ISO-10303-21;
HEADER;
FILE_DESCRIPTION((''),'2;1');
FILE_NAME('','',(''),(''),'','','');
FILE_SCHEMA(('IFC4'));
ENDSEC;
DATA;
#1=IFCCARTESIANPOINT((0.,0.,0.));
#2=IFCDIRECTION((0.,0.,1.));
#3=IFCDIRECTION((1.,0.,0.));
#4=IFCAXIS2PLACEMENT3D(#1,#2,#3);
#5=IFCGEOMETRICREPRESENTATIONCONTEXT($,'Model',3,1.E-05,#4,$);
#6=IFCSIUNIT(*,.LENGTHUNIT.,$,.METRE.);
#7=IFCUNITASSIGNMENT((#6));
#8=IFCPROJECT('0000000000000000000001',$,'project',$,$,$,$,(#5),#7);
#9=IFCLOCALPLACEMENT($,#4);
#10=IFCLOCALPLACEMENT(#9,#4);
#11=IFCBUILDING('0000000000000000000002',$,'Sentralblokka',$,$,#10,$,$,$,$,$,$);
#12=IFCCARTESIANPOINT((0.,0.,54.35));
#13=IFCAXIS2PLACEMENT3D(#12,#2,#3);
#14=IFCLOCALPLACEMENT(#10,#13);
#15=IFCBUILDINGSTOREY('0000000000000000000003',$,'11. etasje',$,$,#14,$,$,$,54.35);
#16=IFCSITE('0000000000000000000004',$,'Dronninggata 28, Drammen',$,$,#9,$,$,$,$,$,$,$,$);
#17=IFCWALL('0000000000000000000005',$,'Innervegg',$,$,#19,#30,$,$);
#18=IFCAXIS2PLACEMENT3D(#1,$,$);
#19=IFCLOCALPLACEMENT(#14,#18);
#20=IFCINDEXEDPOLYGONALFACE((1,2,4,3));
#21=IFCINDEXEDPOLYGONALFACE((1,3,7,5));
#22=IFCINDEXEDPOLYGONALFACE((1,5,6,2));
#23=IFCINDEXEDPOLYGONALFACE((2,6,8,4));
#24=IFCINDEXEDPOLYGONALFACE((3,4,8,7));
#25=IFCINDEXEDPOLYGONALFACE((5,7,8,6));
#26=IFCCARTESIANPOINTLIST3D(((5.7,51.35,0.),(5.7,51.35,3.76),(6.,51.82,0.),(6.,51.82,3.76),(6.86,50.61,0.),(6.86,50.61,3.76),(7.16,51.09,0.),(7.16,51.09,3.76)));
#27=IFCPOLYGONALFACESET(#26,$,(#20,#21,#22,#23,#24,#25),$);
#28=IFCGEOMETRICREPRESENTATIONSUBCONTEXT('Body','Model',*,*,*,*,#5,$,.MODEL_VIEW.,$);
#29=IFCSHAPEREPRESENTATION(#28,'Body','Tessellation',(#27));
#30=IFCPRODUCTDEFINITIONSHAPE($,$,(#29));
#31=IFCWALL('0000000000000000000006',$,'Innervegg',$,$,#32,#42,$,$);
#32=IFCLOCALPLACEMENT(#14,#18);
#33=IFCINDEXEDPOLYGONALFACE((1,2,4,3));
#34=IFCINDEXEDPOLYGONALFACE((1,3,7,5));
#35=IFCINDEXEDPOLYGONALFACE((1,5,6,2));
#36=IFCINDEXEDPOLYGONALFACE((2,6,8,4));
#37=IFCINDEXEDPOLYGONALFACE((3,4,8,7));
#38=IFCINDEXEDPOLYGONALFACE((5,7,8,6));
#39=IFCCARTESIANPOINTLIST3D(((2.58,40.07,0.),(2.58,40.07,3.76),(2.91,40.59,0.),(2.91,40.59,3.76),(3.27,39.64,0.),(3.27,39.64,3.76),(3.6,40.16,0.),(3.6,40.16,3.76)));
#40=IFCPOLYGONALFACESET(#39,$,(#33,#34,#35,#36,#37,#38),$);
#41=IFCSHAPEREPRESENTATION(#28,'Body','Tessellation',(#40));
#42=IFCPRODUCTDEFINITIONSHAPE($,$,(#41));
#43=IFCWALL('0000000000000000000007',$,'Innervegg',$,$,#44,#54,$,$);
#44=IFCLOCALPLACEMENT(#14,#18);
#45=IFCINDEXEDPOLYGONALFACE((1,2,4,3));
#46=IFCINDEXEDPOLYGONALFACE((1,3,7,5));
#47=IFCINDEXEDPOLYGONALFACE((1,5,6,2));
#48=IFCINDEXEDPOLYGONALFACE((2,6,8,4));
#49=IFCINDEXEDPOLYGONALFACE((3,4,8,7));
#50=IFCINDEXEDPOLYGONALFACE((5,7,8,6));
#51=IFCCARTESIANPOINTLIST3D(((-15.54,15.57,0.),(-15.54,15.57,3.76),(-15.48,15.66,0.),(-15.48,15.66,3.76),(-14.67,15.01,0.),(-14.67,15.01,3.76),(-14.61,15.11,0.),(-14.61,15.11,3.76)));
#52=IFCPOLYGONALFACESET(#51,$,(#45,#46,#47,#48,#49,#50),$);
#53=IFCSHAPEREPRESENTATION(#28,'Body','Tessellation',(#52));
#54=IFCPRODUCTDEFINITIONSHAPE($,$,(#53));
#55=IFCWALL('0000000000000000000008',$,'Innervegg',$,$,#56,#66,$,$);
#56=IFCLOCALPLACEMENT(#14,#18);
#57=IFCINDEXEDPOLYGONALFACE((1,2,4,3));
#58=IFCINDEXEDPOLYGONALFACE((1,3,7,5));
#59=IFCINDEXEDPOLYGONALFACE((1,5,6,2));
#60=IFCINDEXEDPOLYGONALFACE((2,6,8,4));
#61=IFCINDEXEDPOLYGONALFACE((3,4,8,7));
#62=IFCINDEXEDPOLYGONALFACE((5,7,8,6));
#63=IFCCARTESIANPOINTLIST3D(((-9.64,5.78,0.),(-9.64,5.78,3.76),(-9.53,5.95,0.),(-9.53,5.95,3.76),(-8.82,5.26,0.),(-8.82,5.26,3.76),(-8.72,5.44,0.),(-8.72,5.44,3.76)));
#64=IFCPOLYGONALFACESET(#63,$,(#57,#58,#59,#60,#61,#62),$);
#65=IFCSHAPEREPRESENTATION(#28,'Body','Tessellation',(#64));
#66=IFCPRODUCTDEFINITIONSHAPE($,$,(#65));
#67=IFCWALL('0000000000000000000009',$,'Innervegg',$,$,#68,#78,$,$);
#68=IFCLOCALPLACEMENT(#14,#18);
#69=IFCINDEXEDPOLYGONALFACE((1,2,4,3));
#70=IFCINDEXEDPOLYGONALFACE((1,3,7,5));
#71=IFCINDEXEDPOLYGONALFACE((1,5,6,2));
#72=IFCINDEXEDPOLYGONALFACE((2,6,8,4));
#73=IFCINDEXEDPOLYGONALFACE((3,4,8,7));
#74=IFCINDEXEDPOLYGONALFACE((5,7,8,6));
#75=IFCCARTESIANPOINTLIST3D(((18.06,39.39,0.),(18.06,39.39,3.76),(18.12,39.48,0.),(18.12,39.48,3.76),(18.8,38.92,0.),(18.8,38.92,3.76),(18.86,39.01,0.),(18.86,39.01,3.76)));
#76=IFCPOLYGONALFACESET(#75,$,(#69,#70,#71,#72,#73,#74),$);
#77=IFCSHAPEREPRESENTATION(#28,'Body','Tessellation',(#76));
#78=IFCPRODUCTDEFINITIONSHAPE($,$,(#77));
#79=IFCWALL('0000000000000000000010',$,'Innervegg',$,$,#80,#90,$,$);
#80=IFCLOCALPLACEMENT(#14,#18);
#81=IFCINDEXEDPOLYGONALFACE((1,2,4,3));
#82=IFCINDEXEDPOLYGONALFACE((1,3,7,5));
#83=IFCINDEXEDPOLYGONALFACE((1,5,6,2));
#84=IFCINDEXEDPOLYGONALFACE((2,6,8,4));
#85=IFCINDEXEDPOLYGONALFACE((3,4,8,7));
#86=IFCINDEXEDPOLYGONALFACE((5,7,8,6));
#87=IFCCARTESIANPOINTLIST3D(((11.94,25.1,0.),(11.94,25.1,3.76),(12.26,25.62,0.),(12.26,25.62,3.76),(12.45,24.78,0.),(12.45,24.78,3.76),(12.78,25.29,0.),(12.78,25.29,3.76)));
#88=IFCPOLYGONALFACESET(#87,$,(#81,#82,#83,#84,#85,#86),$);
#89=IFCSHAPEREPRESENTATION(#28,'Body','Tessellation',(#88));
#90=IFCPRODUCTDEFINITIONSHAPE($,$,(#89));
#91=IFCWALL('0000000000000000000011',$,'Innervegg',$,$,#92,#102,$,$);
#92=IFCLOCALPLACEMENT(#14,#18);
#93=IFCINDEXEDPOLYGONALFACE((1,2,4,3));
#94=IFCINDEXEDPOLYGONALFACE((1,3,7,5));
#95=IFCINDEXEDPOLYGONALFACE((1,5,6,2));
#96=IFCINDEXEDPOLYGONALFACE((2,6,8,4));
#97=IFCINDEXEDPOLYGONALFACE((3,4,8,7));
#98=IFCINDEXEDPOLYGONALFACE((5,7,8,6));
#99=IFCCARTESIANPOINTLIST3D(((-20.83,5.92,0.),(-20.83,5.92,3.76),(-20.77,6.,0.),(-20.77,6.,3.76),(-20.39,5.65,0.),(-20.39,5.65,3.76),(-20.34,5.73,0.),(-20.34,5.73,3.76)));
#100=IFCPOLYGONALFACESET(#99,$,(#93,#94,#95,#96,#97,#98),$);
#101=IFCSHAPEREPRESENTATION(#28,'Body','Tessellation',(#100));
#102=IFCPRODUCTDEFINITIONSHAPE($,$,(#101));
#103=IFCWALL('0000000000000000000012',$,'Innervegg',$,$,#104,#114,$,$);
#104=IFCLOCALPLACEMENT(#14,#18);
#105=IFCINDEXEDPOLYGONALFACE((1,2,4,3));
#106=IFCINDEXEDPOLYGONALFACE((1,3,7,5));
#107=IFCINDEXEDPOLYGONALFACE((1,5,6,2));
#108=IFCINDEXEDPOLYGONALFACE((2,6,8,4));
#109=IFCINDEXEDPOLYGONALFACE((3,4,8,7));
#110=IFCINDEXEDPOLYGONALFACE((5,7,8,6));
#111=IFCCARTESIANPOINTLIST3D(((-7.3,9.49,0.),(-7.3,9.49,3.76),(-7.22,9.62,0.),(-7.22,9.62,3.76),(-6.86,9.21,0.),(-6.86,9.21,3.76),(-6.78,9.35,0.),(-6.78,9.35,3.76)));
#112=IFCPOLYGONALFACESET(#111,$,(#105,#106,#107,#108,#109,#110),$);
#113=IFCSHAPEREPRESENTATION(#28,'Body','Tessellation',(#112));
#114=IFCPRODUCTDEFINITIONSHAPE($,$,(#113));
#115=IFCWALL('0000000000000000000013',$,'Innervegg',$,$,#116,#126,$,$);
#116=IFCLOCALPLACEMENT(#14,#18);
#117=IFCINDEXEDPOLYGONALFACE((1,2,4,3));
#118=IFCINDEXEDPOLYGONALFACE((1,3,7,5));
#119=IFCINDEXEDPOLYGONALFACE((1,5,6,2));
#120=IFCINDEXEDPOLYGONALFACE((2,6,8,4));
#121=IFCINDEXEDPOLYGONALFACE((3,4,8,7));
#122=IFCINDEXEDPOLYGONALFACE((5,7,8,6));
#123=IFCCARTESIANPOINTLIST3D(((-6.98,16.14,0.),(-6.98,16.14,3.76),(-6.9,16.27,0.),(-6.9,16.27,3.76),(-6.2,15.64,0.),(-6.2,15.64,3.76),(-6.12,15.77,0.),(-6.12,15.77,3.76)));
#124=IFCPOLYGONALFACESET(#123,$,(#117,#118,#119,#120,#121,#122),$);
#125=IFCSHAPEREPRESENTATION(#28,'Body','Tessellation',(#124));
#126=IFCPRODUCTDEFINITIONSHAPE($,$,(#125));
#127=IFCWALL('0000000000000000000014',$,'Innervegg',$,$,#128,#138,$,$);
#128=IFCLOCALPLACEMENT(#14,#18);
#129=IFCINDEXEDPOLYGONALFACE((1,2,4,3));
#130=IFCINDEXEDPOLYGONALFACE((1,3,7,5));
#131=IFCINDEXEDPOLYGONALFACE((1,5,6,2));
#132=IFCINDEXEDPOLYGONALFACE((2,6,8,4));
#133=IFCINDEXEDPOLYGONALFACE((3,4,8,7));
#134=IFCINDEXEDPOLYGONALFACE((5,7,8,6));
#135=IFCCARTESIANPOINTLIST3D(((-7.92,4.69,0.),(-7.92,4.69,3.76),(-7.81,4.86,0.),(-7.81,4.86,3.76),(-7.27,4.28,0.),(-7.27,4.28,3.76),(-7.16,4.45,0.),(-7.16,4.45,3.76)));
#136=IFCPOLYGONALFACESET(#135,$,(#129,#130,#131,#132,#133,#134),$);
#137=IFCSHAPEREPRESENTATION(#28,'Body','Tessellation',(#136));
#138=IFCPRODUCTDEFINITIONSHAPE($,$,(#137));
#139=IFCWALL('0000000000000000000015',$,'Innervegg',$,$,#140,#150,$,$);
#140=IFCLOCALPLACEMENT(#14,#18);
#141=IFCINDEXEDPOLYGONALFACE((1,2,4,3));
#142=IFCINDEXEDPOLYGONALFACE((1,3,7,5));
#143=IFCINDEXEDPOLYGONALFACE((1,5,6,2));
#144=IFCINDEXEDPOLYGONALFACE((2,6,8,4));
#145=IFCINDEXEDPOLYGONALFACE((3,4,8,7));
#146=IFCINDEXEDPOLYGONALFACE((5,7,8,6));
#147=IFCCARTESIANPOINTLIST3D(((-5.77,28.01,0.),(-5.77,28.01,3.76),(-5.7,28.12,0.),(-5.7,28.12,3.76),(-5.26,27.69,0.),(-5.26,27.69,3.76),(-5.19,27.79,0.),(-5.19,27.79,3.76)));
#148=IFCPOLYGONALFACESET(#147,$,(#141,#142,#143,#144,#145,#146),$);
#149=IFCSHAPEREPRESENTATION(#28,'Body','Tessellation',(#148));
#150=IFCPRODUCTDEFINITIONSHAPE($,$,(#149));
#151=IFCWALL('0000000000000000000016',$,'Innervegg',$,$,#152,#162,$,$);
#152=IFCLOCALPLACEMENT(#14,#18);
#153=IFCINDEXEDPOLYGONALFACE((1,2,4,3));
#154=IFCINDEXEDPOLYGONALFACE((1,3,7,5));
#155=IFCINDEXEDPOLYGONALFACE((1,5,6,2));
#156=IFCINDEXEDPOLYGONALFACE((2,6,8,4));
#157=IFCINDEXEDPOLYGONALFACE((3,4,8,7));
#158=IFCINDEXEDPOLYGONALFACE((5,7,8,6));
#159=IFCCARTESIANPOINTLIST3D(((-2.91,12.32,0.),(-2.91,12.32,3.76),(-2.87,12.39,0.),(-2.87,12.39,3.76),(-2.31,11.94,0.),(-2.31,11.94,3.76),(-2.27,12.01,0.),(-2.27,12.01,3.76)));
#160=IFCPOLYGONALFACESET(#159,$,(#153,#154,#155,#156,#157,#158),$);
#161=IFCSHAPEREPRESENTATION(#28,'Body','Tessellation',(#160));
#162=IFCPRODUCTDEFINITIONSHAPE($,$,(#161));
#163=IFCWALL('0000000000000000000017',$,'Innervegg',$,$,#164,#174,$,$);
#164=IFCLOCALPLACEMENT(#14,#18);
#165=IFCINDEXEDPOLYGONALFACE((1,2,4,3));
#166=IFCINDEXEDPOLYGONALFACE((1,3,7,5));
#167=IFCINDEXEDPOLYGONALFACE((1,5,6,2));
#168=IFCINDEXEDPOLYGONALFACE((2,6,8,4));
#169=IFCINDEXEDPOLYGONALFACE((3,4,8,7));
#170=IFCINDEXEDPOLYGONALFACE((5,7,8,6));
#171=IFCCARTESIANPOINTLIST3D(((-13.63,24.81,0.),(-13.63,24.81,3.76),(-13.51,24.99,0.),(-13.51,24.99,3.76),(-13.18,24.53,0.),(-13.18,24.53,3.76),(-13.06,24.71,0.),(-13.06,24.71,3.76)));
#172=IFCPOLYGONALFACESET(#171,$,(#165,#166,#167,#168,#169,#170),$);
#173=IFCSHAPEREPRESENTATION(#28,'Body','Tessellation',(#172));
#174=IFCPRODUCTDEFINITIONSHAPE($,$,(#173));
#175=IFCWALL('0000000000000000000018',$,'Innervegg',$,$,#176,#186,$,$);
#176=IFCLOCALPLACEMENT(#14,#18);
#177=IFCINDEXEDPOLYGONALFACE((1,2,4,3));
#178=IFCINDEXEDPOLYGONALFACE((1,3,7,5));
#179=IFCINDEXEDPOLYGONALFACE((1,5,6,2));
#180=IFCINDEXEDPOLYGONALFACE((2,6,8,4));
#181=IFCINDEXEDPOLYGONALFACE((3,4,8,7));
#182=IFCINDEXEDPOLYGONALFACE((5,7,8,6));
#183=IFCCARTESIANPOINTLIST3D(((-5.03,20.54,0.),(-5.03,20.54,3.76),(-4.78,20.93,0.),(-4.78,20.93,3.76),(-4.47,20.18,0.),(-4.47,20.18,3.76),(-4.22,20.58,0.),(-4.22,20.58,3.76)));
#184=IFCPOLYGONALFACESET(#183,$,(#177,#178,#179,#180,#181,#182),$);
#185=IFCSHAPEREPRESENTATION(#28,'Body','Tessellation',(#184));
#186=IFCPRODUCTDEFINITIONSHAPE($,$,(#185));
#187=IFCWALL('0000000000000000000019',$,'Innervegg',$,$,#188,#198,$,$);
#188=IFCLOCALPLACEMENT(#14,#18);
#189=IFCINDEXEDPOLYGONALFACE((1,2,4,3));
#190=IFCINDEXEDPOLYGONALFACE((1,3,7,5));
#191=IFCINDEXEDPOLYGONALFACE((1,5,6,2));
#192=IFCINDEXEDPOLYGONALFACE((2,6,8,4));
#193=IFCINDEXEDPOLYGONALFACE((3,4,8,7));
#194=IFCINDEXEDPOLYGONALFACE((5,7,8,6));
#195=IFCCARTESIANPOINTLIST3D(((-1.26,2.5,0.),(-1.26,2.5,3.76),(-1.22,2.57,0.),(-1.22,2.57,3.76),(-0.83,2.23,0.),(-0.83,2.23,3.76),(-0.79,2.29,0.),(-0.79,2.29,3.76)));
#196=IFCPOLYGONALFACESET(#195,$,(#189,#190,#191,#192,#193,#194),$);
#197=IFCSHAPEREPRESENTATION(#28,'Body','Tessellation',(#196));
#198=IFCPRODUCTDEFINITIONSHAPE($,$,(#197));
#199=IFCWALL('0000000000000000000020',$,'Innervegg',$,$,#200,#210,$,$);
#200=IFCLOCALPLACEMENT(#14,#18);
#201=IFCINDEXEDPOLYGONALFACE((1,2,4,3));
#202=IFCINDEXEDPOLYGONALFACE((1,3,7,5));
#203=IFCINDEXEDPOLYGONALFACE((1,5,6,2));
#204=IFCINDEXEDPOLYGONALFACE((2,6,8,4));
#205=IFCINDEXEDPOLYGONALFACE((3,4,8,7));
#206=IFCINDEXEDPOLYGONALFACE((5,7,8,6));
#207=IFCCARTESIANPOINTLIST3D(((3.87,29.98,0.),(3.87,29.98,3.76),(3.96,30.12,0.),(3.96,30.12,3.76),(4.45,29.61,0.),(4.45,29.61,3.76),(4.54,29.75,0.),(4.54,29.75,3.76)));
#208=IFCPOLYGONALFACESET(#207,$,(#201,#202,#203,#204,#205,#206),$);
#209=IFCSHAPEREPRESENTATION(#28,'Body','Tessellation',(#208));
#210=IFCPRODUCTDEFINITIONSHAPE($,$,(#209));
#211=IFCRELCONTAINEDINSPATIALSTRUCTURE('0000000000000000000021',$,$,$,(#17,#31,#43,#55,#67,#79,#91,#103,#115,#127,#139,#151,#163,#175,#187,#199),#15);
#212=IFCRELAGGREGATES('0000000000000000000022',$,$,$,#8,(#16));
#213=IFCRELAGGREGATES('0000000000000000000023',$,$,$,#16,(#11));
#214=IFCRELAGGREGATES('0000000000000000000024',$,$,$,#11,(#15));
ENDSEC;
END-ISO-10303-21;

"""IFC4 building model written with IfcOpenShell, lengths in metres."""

from ifc_helpers import new_model, si_unit, frame, origin_with_axes, place, context, subcontext, project, spatial, polyline, outline, extrude, element, save


model = new_model("IFC4")

# Units and contexts
model_context = context("Model", 3, precision=1e-05, world=origin_with_axes())
body_context = subcontext(model_context, "Body", "Model", "MODEL_VIEW")
ifc_project = project(units=[si_unit("LENGTHUNIT", "METRE")], contexts=[model_context])

# Site, building, storey
site_placement = place(None, origin_with_axes())
site = spatial("IfcSite", under=ifc_project, at=site_placement, Name="Dronninggata 28, Drammen")
building_placement = place(site_placement, origin_with_axes())
building = spatial("IfcBuilding", under=site, at=building_placement, Name="Sentralblokka")
storey_placement = place(building_placement, frame((0.0, 0.0, 54.35), z_axis=(0.0, 0.0, 1.0), x_axis=(1.0, 0.0, 0.0)))
storey = spatial("IfcBuildingStorey", under=building, at=storey_placement, Name="11. etasje", Elevation=54.35)

# Walls
wall_1_placement = place(storey_placement, frame((0.0, 0.0, -54.35), z_axis=(0.0, 0.0, 1.0), x_axis=(1.0, 0.0, 0.0)))
element("IfcWall", 1, at=wall_1_placement, inside=storey, Name="Innervegg", context=body_context, shape_type="SweptSolid", body=[
    extrude(outline(polyline([(7.16, 51.09), (6.86, 50.61), (5.7, 51.35), (6.0, 51.82), (7.16, 51.09)])), frame((0.0, 0.0, 54.35)), (0.0, 0.0, 1.0), 3.76),
])
wall_2_placement = place(storey_placement, frame((0.0, 0.0, -54.35), z_axis=(0.0, 0.0, 1.0), x_axis=(1.0, 0.0, 0.0)))
element("IfcWall", 2, at=wall_2_placement, inside=storey, Name="Innervegg", context=body_context, shape_type="SweptSolid", body=[
    extrude(outline(polyline([(3.6, 40.16), (3.27, 39.64), (2.58, 40.07), (2.91, 40.59), (3.6, 40.16)])), frame((0.0, 0.0, 54.35)), (0.0, 0.0, 1.0), 3.76),
])
wall_3_placement = place(storey_placement, frame((0.0, 0.0, -54.35), z_axis=(0.0, 0.0, 1.0), x_axis=(1.0, 0.0, 0.0)))
element("IfcWall", 3, at=wall_3_placement, inside=storey, Name="Innervegg", context=body_context, shape_type="SweptSolid", body=[
    extrude(outline(polyline([(-14.61, 15.11), (-14.67, 15.01), (-15.54, 15.57), (-15.48, 15.66), (-14.61, 15.11)])), frame((0.0, 0.0, 54.35)), (0.0, 0.0, 1.0), 3.76),
])
wall_4_placement = place(storey_placement, frame((0.0, 0.0, -54.35), z_axis=(0.0, 0.0, 1.0), x_axis=(1.0, 0.0, 0.0)))
element("IfcWall", 4, at=wall_4_placement, inside=storey, Name="Innervegg", context=body_context, shape_type="SweptSolid", body=[
    extrude(outline(polyline([(-8.72, 5.44), (-8.82, 5.26), (-9.64, 5.78), (-9.53, 5.95), (-8.72, 5.44)])), frame((0.0, 0.0, 54.35)), (0.0, 0.0, 1.0), 3.76),
])
wall_5_placement = place(storey_placement, frame((0.0, 0.0, -54.35), z_axis=(0.0, 0.0, 1.0), x_axis=(1.0, 0.0, 0.0)))
element("IfcWall", 5, at=wall_5_placement, inside=storey, Name="Innervegg", context=body_context, shape_type="SweptSolid", body=[
    extrude(outline(polyline([(18.86, 39.01), (18.8, 38.92), (18.06, 39.39), (18.12, 39.48), (18.86, 39.01)])), frame((0.0, 0.0, 54.35)), (0.0, 0.0, 1.0), 3.76),
])
wall_6_placement = place(storey_placement, frame((0.0, 0.0, -54.35), z_axis=(0.0, 0.0, 1.0), x_axis=(1.0, 0.0, 0.0)))
element("IfcWall", 6, at=wall_6_placement, inside=storey, Name="Innervegg", context=body_context, shape_type="SweptSolid", body=[
    extrude(outline(polyline([(12.78, 25.29), (12.45, 24.78), (11.94, 25.1), (12.26, 25.62), (12.78, 25.29)])), frame((0.0, 0.0, 54.35)), (0.0, 0.0, 1.0), 3.76),
])
wall_7_placement = place(storey_placement, frame((0.0, 0.0, -54.35), z_axis=(0.0, 0.0, 1.0), x_axis=(1.0, 0.0, 0.0)))
element("IfcWall", 7, at=wall_7_placement, inside=storey, Name="Innervegg", context=body_context, shape_type="SweptSolid", body=[
    extrude(outline(polyline([(-20.34, 5.73), (-20.39, 5.65), (-20.83, 5.92), (-20.77, 6.0), (-20.34, 5.73)])), frame((0.0, 0.0, 54.35)), (0.0, 0.0, 1.0), 3.76),
])
wall_8_placement = place(storey_placement, frame((0.0, 0.0, -54.35), z_axis=(0.0, 0.0, 1.0), x_axis=(1.0, 0.0, 0.0)))
element("IfcWall", 8, at=wall_8_placement, inside=storey, Name="Innervegg", context=body_context, shape_type="SweptSolid", body=[
    extrude(outline(polyline([(-6.78, 9.35), (-6.86, 9.21), (-7.3, 9.49), (-7.22, 9.62), (-6.78, 9.35)])), frame((0.0, 0.0, 54.35)), (0.0, 0.0, 1.0), 3.76),
])
wall_9_placement = place(storey_placement, frame((0.0, 0.0, -54.35), z_axis=(0.0, 0.0, 1.0), x_axis=(1.0, 0.0, 0.0)))
element("IfcWall", 9, at=wall_9_placement, inside=storey, Name="Innervegg", context=body_context, shape_type="SweptSolid", body=[
    extrude(outline(polyline([(-6.12, 15.77), (-6.2, 15.64), (-6.98, 16.14), (-6.9, 16.27), (-6.12, 15.77)])), frame((0.0, 0.0, 54.35)), (0.0, 0.0, 1.0), 3.76),
])
wall_10_placement = place(storey_placement, frame((0.0, 0.0, -54.35), z_axis=(0.0, 0.0, 1.0), x_axis=(1.0, 0.0, 0.0)))
element("IfcWall", 10, at=wall_10_placement, inside=storey, Name="Innervegg", context=body_context, shape_type="SweptSolid", body=[
    extrude(outline(polyline([(-7.16, 4.45), (-7.27, 4.28), (-7.92, 4.69), (-7.81, 4.86), (-7.16, 4.45)])), frame((0.0, 0.0, 54.35)), (0.0, 0.0, 1.0), 3.76),
])
wall_11_placement = place(storey_placement, frame((0.0, 0.0, -54.35), z_axis=(0.0, 0.0, 1.0), x_axis=(1.0, 0.0, 0.0)))
element("IfcWall", 11, at=wall_11_placement, inside=storey, Name="Innervegg", context=body_context, shape_type="SweptSolid", body=[
    extrude(outline(polyline([(-5.19, 27.79), (-5.26, 27.69), (-5.77, 28.01), (-5.7, 28.12), (-5.19, 27.79)])), frame((0.0, 0.0, 54.35)), (0.0, 0.0, 1.0), 3.76),
])
wall_12_placement = place(storey_placement, frame((0.0, 0.0, -54.35), z_axis=(0.0, 0.0, 1.0), x_axis=(1.0, 0.0, 0.0)))
element("IfcWall", 12, at=wall_12_placement, inside=storey, Name="Innervegg", context=body_context, shape_type="SweptSolid", body=[
    extrude(outline(polyline([(-2.27, 12.01), (-2.31, 11.94), (-2.91, 12.32), (-2.87, 12.39), (-2.27, 12.01)])), frame((0.0, 0.0, 54.35)), (0.0, 0.0, 1.0), 3.76),
])
wall_13_placement = place(storey_placement, frame((0.0, 0.0, -54.35), z_axis=(0.0, 0.0, 1.0), x_axis=(1.0, 0.0, 0.0)))
element("IfcWall", 13, at=wall_13_placement, inside=storey, Name="Innervegg", context=body_context, shape_type="SweptSolid", body=[
    extrude(outline(polyline([(-13.06, 24.71), (-13.18, 24.53), (-13.63, 24.81), (-13.51, 24.99), (-13.06, 24.71)])), frame((0.0, 0.0, 54.35)), (0.0, 0.0, 1.0), 3.76),
])
wall_14_placement = place(storey_placement, frame((0.0, 0.0, -54.35), z_axis=(0.0, 0.0, 1.0), x_axis=(1.0, 0.0, 0.0)))
element("IfcWall", 14, at=wall_14_placement, inside=storey, Name="Innervegg", context=body_context, shape_type="SweptSolid", body=[
    extrude(outline(polyline([(-4.22, 20.58), (-4.47, 20.18), (-5.03, 20.54), (-4.78, 20.93), (-4.22, 20.58)])), frame((0.0, 0.0, 54.35)), (0.0, 0.0, 1.0), 3.76),
])
wall_15_placement = place(storey_placement, frame((0.0, 0.0, -54.35), z_axis=(0.0, 0.0, 1.0), x_axis=(1.0, 0.0, 0.0)))
element("IfcWall", 15, at=wall_15_placement, inside=storey, Name="Innervegg", context=body_context, shape_type="SweptSolid", body=[
    extrude(outline(polyline([(-0.79, 2.29), (-0.83, 2.23), (-1.26, 2.5), (-1.22, 2.57), (-0.79, 2.29)])), frame((0.0, 0.0, 54.35)), (0.0, 0.0, 1.0), 3.76),
])
wall_16_placement = place(storey_placement, frame((0.0, 0.0, -54.35), z_axis=(0.0, 0.0, 1.0), x_axis=(1.0, 0.0, 0.0)))
element("IfcWall", 16, at=wall_16_placement, inside=storey, Name="Innervegg", context=body_context, shape_type="SweptSolid", body=[
    extrude(outline(polyline([(4.54, 29.75), (4.45, 29.61), (3.87, 29.98), (3.96, 30.12), (4.54, 29.75)])), frame((0.0, 0.0, 54.35)), (0.0, 0.0, 1.0), 3.76),
])

save(model, "model.ifc")
